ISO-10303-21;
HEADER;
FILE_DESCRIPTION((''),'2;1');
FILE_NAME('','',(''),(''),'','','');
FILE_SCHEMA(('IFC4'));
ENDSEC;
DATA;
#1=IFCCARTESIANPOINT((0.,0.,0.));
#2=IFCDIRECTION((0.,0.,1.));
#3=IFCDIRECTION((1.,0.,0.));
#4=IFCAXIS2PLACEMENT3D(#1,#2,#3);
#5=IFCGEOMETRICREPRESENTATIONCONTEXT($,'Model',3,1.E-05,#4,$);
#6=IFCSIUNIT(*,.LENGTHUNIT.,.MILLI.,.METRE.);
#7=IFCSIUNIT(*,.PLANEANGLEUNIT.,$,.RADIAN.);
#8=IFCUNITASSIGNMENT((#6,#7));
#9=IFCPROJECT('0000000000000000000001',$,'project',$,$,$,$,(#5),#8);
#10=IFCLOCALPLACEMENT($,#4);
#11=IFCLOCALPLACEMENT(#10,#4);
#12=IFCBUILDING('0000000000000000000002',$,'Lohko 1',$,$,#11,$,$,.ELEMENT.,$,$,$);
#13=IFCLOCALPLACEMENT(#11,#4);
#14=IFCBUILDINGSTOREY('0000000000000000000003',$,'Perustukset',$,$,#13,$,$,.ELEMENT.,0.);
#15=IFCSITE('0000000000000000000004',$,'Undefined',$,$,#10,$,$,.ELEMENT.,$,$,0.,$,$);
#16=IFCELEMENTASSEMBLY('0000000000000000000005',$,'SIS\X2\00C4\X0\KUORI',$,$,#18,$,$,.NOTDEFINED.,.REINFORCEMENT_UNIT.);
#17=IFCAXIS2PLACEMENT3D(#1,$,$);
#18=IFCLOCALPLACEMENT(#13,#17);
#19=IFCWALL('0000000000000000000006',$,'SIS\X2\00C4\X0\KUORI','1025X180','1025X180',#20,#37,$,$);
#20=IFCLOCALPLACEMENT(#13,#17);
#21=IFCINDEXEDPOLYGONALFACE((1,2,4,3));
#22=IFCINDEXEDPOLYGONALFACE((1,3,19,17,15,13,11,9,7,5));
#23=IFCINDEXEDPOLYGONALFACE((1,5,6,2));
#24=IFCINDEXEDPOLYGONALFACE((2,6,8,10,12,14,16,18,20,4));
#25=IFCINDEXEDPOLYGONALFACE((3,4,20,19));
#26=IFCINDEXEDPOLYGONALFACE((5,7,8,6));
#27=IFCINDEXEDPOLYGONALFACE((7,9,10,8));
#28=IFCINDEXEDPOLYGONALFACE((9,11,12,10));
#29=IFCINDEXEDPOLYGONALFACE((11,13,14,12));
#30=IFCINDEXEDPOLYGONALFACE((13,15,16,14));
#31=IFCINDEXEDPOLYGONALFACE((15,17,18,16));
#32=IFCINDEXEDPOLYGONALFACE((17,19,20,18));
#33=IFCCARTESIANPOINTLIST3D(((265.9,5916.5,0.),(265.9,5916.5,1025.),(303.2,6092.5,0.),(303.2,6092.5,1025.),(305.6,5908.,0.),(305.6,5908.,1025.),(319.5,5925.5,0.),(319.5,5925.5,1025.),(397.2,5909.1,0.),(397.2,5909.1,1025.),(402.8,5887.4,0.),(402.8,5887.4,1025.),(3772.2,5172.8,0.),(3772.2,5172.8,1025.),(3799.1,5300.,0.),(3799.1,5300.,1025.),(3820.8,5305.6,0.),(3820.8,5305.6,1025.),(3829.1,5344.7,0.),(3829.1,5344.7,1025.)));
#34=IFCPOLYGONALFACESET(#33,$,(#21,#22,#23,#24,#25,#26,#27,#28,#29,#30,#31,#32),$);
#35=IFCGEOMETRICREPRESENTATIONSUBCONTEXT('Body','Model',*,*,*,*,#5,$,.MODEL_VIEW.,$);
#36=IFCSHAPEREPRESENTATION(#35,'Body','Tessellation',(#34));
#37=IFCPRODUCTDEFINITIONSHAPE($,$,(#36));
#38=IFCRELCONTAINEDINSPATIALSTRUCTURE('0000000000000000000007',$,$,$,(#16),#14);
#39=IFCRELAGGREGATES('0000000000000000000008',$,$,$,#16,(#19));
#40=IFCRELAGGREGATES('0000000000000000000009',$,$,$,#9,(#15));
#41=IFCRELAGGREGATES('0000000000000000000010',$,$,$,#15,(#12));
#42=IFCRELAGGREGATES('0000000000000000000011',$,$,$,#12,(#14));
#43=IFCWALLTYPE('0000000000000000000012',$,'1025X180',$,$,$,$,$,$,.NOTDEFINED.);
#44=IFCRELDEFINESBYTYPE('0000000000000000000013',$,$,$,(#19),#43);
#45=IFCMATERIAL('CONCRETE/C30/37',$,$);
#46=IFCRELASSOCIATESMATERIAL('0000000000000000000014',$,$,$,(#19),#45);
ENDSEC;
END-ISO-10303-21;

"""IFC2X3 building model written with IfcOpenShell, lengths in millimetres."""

from ifc_helpers import new_model, si_unit, frame, frame_2d, origin_with_axes, place, context, subcontext, project, spatial, polyline, rectangle, outline, extrude, boolean, material, type_object, element, aggregate, save


model = new_model("IFC2X3")

# Units and contexts
model_context = context("Model", 3, precision=1e-05, world=origin_with_axes())
body_context = subcontext(model_context, "Body", "Model", "MODEL_VIEW")
ifc_project = project(units=[si_unit("LENGTHUNIT", "METRE", prefix="MILLI"), si_unit("PLANEANGLEUNIT", "RADIAN")], contexts=[model_context])

# Site, building, storey
site_placement = place(None, origin_with_axes())
site = spatial("IfcSite", under=ifc_project, at=site_placement, Name="Undefined", CompositionType="ELEMENT", RefElevation=0.0)
building_placement = place(site_placement, origin_with_axes())
building = spatial("IfcBuilding", under=site, at=building_placement, Name="Lohko 1", CompositionType="ELEMENT")
storey_placement = place(building_placement, origin_with_axes())
storey = spatial("IfcBuildingStorey", under=building, at=storey_placement, Name="Perustukset", CompositionType="ELEMENT", Elevation=0.0)

# Element assembly, wall
assembly_placement = place(storey_placement, origin_with_axes())
assembly = element("IfcElementAssembly", 1, at=assembly_placement, inside=storey, Name="SISÄKUORI", AssemblyPlace="NOTDEFINED", PredefinedType="REINFORCEMENT_UNIT")
ifc_material_1 = material(Name="CONCRETE/C30/37")
wall_type = type_object("IfcWallType", Name="1025X180", PredefinedType="NOTDEFINED")
wall_placement = place(assembly_placement, frame((284.5, 6004.5, 0.0), z_axis=(0.0, 0.0, 1.0), x_axis=(0.97824, -0.207475, 0.0)))
wall = element("IfcWall", 2, at=wall_placement, type_object=wall_type, material=ifc_material_1, Name="SISÄKUORI", Description="1025X180", ObjectType="1025X180", context=body_context, shape_type="CSG", body=[
    boolean("DIFFERENCE", boolean("DIFFERENCE", extrude(rectangle(XDim=3604.3, YDim=180.0, at=frame_2d((0.0, 1802.1), x_axis=(0.0, -1.0))), frame((0.0, 0.0, 0.0), z_axis=(0.0, 0.0, 1.0), x_axis=(0.0, -1.0, 0.0)), (0.0, 0.0, 1.0), 1025.0), extrude(outline(polyline([(0.0, 0.0), (140.0, 0.0), (130.0, 20.0), (0.0, 20.0), (0.0, 0.0)])), frame((3604.3, -90.0, 0.0), z_axis=(0.0, 0.0, 1.0), x_axis=(0.0, 1.0, 0.0)), (0.0, 0.0, 1.0), 1025.0)), extrude(outline(polyline([(0.0, 0.0), (99.4, 0.0), (89.4, 20.0), (10.0, 20.0), (0.0, 0.0)])), frame((40.6, -90.0, 0.0), z_axis=(0.0, 0.0, 1.0), x_axis=(1.0, 0.0, 0.0)), (0.0, 0.0, 1.0), 1025.0)),
])
aggregate(assembly, [wall])

save(model, "model.ifc")
